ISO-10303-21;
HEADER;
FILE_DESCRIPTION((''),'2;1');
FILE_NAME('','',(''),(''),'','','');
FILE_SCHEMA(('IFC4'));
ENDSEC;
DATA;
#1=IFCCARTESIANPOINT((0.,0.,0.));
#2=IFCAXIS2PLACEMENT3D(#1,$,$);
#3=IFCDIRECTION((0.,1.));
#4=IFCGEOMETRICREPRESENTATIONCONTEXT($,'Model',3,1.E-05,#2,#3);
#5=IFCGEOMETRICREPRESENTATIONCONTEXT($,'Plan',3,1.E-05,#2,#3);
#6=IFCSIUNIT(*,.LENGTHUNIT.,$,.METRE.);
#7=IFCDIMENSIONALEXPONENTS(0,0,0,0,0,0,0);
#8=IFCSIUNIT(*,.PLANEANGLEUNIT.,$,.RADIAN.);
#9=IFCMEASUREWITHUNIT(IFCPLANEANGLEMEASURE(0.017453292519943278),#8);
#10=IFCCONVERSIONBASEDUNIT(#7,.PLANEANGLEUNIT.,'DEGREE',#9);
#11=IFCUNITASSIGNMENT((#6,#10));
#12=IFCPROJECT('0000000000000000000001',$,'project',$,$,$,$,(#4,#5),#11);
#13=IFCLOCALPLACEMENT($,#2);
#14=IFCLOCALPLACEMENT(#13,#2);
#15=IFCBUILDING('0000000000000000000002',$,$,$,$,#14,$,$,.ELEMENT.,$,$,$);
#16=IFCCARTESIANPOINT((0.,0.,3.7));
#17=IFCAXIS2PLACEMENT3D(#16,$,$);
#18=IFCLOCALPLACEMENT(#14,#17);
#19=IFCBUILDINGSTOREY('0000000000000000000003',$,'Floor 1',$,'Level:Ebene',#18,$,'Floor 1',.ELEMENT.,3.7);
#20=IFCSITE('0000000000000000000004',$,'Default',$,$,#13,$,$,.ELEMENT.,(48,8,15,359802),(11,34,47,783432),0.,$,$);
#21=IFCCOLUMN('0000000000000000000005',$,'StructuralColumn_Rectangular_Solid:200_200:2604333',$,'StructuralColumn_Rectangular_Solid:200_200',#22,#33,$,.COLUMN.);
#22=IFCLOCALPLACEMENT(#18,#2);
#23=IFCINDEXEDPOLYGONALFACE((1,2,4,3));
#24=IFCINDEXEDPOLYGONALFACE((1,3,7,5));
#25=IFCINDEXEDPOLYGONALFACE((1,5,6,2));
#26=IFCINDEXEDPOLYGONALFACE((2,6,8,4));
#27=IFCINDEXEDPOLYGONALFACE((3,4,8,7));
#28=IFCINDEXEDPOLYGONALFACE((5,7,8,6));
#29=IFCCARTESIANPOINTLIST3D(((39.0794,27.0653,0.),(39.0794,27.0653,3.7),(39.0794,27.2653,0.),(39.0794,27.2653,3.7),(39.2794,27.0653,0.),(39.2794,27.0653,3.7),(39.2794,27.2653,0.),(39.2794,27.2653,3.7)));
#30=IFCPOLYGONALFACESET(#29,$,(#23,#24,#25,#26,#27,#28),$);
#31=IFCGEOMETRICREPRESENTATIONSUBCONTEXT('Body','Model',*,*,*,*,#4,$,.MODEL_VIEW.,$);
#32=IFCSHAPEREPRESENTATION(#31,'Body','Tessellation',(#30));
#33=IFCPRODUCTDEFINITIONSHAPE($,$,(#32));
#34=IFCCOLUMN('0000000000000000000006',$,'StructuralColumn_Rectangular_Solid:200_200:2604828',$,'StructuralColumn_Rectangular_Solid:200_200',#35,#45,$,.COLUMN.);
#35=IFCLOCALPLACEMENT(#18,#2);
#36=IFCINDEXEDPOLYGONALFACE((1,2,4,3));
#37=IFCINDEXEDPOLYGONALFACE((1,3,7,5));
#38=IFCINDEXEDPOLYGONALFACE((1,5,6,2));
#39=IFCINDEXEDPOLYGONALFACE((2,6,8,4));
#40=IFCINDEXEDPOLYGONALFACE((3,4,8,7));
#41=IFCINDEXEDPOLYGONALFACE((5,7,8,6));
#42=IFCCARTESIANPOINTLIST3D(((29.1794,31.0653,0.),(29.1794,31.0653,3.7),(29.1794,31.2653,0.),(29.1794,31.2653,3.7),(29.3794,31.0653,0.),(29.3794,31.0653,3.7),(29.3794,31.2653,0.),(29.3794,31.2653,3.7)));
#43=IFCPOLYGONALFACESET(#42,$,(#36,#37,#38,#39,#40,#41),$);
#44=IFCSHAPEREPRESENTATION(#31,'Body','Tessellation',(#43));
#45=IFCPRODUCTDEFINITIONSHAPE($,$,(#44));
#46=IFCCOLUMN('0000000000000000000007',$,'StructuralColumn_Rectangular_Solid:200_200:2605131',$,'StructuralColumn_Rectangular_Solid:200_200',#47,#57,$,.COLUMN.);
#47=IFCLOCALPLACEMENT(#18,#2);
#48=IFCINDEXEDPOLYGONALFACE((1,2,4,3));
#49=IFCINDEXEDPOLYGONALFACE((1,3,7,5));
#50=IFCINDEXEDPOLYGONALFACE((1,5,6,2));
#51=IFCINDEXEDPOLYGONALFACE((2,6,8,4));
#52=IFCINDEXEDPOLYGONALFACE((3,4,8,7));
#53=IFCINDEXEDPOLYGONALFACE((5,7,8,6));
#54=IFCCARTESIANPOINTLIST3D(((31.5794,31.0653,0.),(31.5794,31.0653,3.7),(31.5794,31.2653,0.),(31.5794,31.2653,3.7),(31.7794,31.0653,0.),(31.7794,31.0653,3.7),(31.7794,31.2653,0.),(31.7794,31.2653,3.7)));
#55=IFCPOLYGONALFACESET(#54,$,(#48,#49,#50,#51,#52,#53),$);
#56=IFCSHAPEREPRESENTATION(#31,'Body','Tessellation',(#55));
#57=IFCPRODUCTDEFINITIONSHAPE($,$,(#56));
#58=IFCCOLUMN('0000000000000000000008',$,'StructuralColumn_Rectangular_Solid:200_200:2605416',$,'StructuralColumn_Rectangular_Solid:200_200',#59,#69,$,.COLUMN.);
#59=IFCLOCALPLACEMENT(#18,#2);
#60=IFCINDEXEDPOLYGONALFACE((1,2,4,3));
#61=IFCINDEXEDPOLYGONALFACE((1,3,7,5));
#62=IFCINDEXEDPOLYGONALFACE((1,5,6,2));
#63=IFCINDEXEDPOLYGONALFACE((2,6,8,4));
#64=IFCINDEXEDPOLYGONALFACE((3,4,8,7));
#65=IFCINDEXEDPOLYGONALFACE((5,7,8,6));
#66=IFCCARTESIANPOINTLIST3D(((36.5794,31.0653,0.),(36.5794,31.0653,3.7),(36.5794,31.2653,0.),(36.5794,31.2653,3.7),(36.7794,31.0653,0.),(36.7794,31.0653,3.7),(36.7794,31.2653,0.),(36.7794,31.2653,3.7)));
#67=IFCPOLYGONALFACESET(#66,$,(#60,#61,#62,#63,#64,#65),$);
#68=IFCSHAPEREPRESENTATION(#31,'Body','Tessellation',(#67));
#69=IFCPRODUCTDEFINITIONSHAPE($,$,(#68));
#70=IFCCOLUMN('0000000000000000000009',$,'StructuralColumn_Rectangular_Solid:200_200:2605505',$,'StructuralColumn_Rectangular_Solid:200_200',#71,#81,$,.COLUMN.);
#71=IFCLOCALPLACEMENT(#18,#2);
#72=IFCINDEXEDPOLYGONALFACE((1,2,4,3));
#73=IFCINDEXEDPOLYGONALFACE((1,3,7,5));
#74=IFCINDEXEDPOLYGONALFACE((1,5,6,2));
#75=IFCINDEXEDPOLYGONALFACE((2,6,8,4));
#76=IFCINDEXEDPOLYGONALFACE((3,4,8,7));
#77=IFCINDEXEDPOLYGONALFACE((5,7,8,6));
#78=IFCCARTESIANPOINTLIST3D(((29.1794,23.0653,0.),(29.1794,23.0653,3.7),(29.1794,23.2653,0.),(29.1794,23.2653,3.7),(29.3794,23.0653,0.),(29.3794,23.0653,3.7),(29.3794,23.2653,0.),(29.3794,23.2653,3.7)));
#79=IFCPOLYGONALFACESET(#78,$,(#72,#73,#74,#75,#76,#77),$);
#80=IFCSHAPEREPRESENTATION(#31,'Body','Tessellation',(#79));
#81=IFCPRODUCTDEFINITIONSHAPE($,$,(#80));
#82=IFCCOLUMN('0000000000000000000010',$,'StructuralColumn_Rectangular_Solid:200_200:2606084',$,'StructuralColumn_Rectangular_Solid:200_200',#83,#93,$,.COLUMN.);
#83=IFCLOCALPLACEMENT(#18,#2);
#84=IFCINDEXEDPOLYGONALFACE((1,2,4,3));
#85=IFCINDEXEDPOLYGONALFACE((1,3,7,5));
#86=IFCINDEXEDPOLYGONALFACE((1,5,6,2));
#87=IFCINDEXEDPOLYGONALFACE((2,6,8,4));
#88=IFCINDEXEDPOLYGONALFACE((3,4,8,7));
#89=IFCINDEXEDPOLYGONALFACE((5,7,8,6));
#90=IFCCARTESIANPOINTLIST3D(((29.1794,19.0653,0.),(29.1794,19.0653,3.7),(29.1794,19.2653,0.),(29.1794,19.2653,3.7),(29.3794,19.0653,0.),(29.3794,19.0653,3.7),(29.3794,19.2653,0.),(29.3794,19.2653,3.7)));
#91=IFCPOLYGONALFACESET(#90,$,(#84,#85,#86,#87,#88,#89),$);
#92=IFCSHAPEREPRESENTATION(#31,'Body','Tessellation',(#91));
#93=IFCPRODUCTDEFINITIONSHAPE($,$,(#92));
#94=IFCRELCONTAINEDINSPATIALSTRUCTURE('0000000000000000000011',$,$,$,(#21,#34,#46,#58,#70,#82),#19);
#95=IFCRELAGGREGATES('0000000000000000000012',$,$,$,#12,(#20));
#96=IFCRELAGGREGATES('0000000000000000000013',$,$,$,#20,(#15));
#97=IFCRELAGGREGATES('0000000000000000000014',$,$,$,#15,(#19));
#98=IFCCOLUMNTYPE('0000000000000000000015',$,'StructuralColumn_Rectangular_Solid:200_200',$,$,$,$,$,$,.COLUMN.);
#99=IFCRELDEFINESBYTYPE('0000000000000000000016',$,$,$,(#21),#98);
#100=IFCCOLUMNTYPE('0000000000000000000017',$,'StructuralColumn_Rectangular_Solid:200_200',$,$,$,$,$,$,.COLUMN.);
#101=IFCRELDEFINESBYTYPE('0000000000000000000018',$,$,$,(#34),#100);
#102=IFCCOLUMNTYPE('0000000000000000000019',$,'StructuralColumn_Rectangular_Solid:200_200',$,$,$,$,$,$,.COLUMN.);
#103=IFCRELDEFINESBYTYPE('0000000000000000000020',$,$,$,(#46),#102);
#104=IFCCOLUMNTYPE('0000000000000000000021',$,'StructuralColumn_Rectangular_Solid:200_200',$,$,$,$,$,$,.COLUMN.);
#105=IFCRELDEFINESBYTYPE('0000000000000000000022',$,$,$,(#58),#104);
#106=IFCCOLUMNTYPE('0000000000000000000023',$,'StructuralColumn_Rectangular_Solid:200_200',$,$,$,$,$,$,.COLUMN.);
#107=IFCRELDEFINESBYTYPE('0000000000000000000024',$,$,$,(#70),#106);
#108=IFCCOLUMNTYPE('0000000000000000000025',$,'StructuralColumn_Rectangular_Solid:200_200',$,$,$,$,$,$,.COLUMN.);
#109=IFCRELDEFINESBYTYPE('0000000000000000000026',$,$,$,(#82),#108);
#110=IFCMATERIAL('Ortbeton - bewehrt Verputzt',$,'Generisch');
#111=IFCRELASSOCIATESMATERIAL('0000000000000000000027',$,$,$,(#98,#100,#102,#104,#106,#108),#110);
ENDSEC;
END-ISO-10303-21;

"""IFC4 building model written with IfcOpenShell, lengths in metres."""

from ifc_helpers import new_model, entity, si_unit, converted_unit, direction, frame, frame_2d, origin, origin_2d_with_axis, place, context, subcontext, project, spatial, rectangle, extrude, source, transform, mapped, material, material_profile, profile_set, type_object, type_shapes, element, save


model = new_model("IFC4")

# Units and contexts
model_context = context("Model", 3, precision=1e-05, world=origin(), true_north=direction((0.0, 1.0)))
plan_context = context("Plan", 3, precision=1e-05, world=origin(), true_north=direction((0.0, 1.0)))
body_context = subcontext(model_context, "Body", "Model", "MODEL_VIEW")
ifc_project = project(units=[si_unit("LENGTHUNIT", "METRE"), converted_unit("PLANEANGLEUNIT", "DEGREE", entity("IfcPlaneAngleMeasure", 0.017453292519943278), si_unit("PLANEANGLEUNIT", "RADIAN"), dimensions=[0, 0, 0, 0, 0, 0, 0])], contexts=[model_context, plan_context])

# Site, building, storey
site_placement = place(None, origin())
site = spatial("IfcSite", under=ifc_project, at=site_placement, Name="Default", CompositionType="ELEMENT", RefLatitude=(48, 8, 15, 359802), RefLongitude=(11, 34, 47, 783432), RefElevation=0.0)
building_placement = place(site_placement, origin())
building = spatial("IfcBuilding", under=site, at=building_placement, CompositionType="ELEMENT")
storey_placement = place(building_placement, frame((0.0, 0.0, 3.7)))
storey = spatial("IfcBuildingStorey", under=building, at=storey_placement, Name="Floor 1", ObjectType="Level:Ebene", LongName="Floor 1", CompositionType="ELEMENT", Elevation=3.7)

# Columns
ifc_material_1 = material(Name="Ortbeton - bewehrt Verputzt", Category="Generisch")
ifc_material_profile = material_profile(ifc_material_1, rectangle(XDim=0.2, YDim=0.2, at=frame_2d((0.0, 0.0), x_axis=(1.0, 0.0))), Name="200_200")
ifc_profile_set = profile_set([ifc_material_profile], Name="200_200")
column_type_1 = type_object("IfcColumnType", Name="StructuralColumn_Rectangular_Solid:200_200", PredefinedType="COLUMN", material=ifc_profile_set)
shared_shape_1 = source(origin(), body_context, "Body", "SweptSolid", [
    extrude(rectangle(XDim=0.2, YDim=0.2, at=frame_2d((0.0, 0.0), x_axis=(1.0, 0.0))), frame((39.1794, 27.1653, 3.7), z_axis=(0.0, 0.0, 1.0), x_axis=(-1.0, 0.0, 0.0)), (0.0, 0.0, 1.0), 3.7),
])
type_shapes(column_type_1, [shared_shape_1])
column_1_placement = place(storey_placement, frame((0.0, 0.0, -3.7)))
element("IfcColumn", 1, at=column_1_placement, inside=storey, type_object=column_type_1, Name="StructuralColumn_Rectangular_Solid:200_200:2604333", ObjectType="StructuralColumn_Rectangular_Solid:200_200", PredefinedType="COLUMN", context=body_context, shape_type="MappedRepresentation", body=[
    mapped(shared_shape_1, transform((0.0, 0.0, 0.0), scale=1.0)),
])
column_type_2 = type_object("IfcColumnType", Name="StructuralColumn_Rectangular_Solid:200_200", PredefinedType="COLUMN", material=ifc_profile_set)
shared_shape_2 = source(origin(), body_context, "Body", "SweptSolid", [
    extrude(rectangle(XDim=0.2, YDim=0.2, at=origin_2d_with_axis()), frame((29.2794, 31.1653, 3.7), z_axis=(0.0, 0.0, 1.0), x_axis=(-1.0, 0.0, 0.0)), (0.0, 0.0, 1.0), 3.7),
])
type_shapes(column_type_2, [shared_shape_2])
column_2_placement = place(storey_placement, frame((0.0, 0.0, -3.7)))
element("IfcColumn", 2, at=column_2_placement, inside=storey, type_object=column_type_2, Name="StructuralColumn_Rectangular_Solid:200_200:2604828", ObjectType="StructuralColumn_Rectangular_Solid:200_200", PredefinedType="COLUMN", context=body_context, shape_type="MappedRepresentation", body=[
    mapped(shared_shape_2, transform((0.0, 0.0, 0.0), scale=1.0)),
])
column_type_3 = type_object("IfcColumnType", Name="StructuralColumn_Rectangular_Solid:200_200", PredefinedType="COLUMN", material=ifc_profile_set)
shared_shape_3 = source(origin(), body_context, "Body", "SweptSolid", [
    extrude(rectangle(XDim=0.2, YDim=0.2, at=origin_2d_with_axis()), frame((31.6794, 31.1653, 3.7), z_axis=(0.0, 0.0, 1.0), x_axis=(-1.0, 0.0, 0.0)), (0.0, 0.0, 1.0), 3.7),
])
type_shapes(column_type_3, [shared_shape_3])
column_3_placement = place(storey_placement, frame((0.0, 0.0, -3.7)))
element("IfcColumn", 3, at=column_3_placement, inside=storey, type_object=column_type_3, Name="StructuralColumn_Rectangular_Solid:200_200:2605131", ObjectType="StructuralColumn_Rectangular_Solid:200_200", PredefinedType="COLUMN", context=body_context, shape_type="MappedRepresentation", body=[
    mapped(shared_shape_3, transform((0.0, 0.0, 0.0), scale=1.0)),
])
column_type_4 = type_object("IfcColumnType", Name="StructuralColumn_Rectangular_Solid:200_200", PredefinedType="COLUMN", material=ifc_profile_set)
shared_shape_4 = source(origin(), body_context, "Body", "SweptSolid", [
    extrude(rectangle(XDim=0.2, YDim=0.2, at=frame_2d((0.0, 0.0), x_axis=(1.0, 0.0))), frame((36.6794, 31.1653, 3.7), z_axis=(0.0, 0.0, 1.0), x_axis=(-1.0, 0.0, 0.0)), (0.0, 0.0, 1.0), 3.7),
])
type_shapes(column_type_4, [shared_shape_4])
column_4_placement = place(storey_placement, frame((0.0, 0.0, -3.7)))
element("IfcColumn", 4, at=column_4_placement, inside=storey, type_object=column_type_4, Name="StructuralColumn_Rectangular_Solid:200_200:2605416", ObjectType="StructuralColumn_Rectangular_Solid:200_200", PredefinedType="COLUMN", context=body_context, shape_type="MappedRepresentation", body=[
    mapped(shared_shape_4, transform((0.0, 0.0, 0.0), scale=1.0)),
])
column_type_5 = type_object("IfcColumnType", Name="StructuralColumn_Rectangular_Solid:200_200", PredefinedType="COLUMN", material=ifc_profile_set)
shared_shape_5 = source(origin(), body_context, "Body", "SweptSolid", [
    extrude(rectangle(XDim=0.2, YDim=0.2, at=origin_2d_with_axis()), frame((29.2794, 23.1653, 3.7), z_axis=(0.0, 0.0, 1.0), x_axis=(-1.0, 0.0, 0.0)), (0.0, 0.0, 1.0), 3.7),
])
type_shapes(column_type_5, [shared_shape_5])
column_5_placement = place(storey_placement, frame((0.0, 0.0, -3.7)))
element("IfcColumn", 5, at=column_5_placement, inside=storey, type_object=column_type_5, Name="StructuralColumn_Rectangular_Solid:200_200:2605505", ObjectType="StructuralColumn_Rectangular_Solid:200_200", PredefinedType="COLUMN", context=body_context, shape_type="MappedRepresentation", body=[
    mapped(shared_shape_5, transform((0.0, 0.0, 0.0), scale=1.0)),
])
column_type_6 = type_object("IfcColumnType", Name="StructuralColumn_Rectangular_Solid:200_200", PredefinedType="COLUMN", material=ifc_profile_set)
shared_shape_6 = source(origin(), body_context, "Body", "SweptSolid", [
    extrude(rectangle(XDim=0.2, YDim=0.2, at=frame_2d((0.0, 0.0), x_axis=(1.0, 0.0))), frame((29.2794, 19.1653, 3.7), z_axis=(0.0, 0.0, 1.0), x_axis=(-1.0, 0.0, 0.0)), (0.0, 0.0, 1.0), 3.7),
])
type_shapes(column_type_6, [shared_shape_6])
column_6_placement = place(storey_placement, frame((0.0, 0.0, -3.7)))
element("IfcColumn", 6, at=column_6_placement, inside=storey, type_object=column_type_6, Name="StructuralColumn_Rectangular_Solid:200_200:2606084", ObjectType="StructuralColumn_Rectangular_Solid:200_200", PredefinedType="COLUMN", context=body_context, shape_type="MappedRepresentation", body=[
    mapped(shared_shape_6, transform((0.0, 0.0, 0.0), scale=1.0)),
])

save(model, "model.ifc")
